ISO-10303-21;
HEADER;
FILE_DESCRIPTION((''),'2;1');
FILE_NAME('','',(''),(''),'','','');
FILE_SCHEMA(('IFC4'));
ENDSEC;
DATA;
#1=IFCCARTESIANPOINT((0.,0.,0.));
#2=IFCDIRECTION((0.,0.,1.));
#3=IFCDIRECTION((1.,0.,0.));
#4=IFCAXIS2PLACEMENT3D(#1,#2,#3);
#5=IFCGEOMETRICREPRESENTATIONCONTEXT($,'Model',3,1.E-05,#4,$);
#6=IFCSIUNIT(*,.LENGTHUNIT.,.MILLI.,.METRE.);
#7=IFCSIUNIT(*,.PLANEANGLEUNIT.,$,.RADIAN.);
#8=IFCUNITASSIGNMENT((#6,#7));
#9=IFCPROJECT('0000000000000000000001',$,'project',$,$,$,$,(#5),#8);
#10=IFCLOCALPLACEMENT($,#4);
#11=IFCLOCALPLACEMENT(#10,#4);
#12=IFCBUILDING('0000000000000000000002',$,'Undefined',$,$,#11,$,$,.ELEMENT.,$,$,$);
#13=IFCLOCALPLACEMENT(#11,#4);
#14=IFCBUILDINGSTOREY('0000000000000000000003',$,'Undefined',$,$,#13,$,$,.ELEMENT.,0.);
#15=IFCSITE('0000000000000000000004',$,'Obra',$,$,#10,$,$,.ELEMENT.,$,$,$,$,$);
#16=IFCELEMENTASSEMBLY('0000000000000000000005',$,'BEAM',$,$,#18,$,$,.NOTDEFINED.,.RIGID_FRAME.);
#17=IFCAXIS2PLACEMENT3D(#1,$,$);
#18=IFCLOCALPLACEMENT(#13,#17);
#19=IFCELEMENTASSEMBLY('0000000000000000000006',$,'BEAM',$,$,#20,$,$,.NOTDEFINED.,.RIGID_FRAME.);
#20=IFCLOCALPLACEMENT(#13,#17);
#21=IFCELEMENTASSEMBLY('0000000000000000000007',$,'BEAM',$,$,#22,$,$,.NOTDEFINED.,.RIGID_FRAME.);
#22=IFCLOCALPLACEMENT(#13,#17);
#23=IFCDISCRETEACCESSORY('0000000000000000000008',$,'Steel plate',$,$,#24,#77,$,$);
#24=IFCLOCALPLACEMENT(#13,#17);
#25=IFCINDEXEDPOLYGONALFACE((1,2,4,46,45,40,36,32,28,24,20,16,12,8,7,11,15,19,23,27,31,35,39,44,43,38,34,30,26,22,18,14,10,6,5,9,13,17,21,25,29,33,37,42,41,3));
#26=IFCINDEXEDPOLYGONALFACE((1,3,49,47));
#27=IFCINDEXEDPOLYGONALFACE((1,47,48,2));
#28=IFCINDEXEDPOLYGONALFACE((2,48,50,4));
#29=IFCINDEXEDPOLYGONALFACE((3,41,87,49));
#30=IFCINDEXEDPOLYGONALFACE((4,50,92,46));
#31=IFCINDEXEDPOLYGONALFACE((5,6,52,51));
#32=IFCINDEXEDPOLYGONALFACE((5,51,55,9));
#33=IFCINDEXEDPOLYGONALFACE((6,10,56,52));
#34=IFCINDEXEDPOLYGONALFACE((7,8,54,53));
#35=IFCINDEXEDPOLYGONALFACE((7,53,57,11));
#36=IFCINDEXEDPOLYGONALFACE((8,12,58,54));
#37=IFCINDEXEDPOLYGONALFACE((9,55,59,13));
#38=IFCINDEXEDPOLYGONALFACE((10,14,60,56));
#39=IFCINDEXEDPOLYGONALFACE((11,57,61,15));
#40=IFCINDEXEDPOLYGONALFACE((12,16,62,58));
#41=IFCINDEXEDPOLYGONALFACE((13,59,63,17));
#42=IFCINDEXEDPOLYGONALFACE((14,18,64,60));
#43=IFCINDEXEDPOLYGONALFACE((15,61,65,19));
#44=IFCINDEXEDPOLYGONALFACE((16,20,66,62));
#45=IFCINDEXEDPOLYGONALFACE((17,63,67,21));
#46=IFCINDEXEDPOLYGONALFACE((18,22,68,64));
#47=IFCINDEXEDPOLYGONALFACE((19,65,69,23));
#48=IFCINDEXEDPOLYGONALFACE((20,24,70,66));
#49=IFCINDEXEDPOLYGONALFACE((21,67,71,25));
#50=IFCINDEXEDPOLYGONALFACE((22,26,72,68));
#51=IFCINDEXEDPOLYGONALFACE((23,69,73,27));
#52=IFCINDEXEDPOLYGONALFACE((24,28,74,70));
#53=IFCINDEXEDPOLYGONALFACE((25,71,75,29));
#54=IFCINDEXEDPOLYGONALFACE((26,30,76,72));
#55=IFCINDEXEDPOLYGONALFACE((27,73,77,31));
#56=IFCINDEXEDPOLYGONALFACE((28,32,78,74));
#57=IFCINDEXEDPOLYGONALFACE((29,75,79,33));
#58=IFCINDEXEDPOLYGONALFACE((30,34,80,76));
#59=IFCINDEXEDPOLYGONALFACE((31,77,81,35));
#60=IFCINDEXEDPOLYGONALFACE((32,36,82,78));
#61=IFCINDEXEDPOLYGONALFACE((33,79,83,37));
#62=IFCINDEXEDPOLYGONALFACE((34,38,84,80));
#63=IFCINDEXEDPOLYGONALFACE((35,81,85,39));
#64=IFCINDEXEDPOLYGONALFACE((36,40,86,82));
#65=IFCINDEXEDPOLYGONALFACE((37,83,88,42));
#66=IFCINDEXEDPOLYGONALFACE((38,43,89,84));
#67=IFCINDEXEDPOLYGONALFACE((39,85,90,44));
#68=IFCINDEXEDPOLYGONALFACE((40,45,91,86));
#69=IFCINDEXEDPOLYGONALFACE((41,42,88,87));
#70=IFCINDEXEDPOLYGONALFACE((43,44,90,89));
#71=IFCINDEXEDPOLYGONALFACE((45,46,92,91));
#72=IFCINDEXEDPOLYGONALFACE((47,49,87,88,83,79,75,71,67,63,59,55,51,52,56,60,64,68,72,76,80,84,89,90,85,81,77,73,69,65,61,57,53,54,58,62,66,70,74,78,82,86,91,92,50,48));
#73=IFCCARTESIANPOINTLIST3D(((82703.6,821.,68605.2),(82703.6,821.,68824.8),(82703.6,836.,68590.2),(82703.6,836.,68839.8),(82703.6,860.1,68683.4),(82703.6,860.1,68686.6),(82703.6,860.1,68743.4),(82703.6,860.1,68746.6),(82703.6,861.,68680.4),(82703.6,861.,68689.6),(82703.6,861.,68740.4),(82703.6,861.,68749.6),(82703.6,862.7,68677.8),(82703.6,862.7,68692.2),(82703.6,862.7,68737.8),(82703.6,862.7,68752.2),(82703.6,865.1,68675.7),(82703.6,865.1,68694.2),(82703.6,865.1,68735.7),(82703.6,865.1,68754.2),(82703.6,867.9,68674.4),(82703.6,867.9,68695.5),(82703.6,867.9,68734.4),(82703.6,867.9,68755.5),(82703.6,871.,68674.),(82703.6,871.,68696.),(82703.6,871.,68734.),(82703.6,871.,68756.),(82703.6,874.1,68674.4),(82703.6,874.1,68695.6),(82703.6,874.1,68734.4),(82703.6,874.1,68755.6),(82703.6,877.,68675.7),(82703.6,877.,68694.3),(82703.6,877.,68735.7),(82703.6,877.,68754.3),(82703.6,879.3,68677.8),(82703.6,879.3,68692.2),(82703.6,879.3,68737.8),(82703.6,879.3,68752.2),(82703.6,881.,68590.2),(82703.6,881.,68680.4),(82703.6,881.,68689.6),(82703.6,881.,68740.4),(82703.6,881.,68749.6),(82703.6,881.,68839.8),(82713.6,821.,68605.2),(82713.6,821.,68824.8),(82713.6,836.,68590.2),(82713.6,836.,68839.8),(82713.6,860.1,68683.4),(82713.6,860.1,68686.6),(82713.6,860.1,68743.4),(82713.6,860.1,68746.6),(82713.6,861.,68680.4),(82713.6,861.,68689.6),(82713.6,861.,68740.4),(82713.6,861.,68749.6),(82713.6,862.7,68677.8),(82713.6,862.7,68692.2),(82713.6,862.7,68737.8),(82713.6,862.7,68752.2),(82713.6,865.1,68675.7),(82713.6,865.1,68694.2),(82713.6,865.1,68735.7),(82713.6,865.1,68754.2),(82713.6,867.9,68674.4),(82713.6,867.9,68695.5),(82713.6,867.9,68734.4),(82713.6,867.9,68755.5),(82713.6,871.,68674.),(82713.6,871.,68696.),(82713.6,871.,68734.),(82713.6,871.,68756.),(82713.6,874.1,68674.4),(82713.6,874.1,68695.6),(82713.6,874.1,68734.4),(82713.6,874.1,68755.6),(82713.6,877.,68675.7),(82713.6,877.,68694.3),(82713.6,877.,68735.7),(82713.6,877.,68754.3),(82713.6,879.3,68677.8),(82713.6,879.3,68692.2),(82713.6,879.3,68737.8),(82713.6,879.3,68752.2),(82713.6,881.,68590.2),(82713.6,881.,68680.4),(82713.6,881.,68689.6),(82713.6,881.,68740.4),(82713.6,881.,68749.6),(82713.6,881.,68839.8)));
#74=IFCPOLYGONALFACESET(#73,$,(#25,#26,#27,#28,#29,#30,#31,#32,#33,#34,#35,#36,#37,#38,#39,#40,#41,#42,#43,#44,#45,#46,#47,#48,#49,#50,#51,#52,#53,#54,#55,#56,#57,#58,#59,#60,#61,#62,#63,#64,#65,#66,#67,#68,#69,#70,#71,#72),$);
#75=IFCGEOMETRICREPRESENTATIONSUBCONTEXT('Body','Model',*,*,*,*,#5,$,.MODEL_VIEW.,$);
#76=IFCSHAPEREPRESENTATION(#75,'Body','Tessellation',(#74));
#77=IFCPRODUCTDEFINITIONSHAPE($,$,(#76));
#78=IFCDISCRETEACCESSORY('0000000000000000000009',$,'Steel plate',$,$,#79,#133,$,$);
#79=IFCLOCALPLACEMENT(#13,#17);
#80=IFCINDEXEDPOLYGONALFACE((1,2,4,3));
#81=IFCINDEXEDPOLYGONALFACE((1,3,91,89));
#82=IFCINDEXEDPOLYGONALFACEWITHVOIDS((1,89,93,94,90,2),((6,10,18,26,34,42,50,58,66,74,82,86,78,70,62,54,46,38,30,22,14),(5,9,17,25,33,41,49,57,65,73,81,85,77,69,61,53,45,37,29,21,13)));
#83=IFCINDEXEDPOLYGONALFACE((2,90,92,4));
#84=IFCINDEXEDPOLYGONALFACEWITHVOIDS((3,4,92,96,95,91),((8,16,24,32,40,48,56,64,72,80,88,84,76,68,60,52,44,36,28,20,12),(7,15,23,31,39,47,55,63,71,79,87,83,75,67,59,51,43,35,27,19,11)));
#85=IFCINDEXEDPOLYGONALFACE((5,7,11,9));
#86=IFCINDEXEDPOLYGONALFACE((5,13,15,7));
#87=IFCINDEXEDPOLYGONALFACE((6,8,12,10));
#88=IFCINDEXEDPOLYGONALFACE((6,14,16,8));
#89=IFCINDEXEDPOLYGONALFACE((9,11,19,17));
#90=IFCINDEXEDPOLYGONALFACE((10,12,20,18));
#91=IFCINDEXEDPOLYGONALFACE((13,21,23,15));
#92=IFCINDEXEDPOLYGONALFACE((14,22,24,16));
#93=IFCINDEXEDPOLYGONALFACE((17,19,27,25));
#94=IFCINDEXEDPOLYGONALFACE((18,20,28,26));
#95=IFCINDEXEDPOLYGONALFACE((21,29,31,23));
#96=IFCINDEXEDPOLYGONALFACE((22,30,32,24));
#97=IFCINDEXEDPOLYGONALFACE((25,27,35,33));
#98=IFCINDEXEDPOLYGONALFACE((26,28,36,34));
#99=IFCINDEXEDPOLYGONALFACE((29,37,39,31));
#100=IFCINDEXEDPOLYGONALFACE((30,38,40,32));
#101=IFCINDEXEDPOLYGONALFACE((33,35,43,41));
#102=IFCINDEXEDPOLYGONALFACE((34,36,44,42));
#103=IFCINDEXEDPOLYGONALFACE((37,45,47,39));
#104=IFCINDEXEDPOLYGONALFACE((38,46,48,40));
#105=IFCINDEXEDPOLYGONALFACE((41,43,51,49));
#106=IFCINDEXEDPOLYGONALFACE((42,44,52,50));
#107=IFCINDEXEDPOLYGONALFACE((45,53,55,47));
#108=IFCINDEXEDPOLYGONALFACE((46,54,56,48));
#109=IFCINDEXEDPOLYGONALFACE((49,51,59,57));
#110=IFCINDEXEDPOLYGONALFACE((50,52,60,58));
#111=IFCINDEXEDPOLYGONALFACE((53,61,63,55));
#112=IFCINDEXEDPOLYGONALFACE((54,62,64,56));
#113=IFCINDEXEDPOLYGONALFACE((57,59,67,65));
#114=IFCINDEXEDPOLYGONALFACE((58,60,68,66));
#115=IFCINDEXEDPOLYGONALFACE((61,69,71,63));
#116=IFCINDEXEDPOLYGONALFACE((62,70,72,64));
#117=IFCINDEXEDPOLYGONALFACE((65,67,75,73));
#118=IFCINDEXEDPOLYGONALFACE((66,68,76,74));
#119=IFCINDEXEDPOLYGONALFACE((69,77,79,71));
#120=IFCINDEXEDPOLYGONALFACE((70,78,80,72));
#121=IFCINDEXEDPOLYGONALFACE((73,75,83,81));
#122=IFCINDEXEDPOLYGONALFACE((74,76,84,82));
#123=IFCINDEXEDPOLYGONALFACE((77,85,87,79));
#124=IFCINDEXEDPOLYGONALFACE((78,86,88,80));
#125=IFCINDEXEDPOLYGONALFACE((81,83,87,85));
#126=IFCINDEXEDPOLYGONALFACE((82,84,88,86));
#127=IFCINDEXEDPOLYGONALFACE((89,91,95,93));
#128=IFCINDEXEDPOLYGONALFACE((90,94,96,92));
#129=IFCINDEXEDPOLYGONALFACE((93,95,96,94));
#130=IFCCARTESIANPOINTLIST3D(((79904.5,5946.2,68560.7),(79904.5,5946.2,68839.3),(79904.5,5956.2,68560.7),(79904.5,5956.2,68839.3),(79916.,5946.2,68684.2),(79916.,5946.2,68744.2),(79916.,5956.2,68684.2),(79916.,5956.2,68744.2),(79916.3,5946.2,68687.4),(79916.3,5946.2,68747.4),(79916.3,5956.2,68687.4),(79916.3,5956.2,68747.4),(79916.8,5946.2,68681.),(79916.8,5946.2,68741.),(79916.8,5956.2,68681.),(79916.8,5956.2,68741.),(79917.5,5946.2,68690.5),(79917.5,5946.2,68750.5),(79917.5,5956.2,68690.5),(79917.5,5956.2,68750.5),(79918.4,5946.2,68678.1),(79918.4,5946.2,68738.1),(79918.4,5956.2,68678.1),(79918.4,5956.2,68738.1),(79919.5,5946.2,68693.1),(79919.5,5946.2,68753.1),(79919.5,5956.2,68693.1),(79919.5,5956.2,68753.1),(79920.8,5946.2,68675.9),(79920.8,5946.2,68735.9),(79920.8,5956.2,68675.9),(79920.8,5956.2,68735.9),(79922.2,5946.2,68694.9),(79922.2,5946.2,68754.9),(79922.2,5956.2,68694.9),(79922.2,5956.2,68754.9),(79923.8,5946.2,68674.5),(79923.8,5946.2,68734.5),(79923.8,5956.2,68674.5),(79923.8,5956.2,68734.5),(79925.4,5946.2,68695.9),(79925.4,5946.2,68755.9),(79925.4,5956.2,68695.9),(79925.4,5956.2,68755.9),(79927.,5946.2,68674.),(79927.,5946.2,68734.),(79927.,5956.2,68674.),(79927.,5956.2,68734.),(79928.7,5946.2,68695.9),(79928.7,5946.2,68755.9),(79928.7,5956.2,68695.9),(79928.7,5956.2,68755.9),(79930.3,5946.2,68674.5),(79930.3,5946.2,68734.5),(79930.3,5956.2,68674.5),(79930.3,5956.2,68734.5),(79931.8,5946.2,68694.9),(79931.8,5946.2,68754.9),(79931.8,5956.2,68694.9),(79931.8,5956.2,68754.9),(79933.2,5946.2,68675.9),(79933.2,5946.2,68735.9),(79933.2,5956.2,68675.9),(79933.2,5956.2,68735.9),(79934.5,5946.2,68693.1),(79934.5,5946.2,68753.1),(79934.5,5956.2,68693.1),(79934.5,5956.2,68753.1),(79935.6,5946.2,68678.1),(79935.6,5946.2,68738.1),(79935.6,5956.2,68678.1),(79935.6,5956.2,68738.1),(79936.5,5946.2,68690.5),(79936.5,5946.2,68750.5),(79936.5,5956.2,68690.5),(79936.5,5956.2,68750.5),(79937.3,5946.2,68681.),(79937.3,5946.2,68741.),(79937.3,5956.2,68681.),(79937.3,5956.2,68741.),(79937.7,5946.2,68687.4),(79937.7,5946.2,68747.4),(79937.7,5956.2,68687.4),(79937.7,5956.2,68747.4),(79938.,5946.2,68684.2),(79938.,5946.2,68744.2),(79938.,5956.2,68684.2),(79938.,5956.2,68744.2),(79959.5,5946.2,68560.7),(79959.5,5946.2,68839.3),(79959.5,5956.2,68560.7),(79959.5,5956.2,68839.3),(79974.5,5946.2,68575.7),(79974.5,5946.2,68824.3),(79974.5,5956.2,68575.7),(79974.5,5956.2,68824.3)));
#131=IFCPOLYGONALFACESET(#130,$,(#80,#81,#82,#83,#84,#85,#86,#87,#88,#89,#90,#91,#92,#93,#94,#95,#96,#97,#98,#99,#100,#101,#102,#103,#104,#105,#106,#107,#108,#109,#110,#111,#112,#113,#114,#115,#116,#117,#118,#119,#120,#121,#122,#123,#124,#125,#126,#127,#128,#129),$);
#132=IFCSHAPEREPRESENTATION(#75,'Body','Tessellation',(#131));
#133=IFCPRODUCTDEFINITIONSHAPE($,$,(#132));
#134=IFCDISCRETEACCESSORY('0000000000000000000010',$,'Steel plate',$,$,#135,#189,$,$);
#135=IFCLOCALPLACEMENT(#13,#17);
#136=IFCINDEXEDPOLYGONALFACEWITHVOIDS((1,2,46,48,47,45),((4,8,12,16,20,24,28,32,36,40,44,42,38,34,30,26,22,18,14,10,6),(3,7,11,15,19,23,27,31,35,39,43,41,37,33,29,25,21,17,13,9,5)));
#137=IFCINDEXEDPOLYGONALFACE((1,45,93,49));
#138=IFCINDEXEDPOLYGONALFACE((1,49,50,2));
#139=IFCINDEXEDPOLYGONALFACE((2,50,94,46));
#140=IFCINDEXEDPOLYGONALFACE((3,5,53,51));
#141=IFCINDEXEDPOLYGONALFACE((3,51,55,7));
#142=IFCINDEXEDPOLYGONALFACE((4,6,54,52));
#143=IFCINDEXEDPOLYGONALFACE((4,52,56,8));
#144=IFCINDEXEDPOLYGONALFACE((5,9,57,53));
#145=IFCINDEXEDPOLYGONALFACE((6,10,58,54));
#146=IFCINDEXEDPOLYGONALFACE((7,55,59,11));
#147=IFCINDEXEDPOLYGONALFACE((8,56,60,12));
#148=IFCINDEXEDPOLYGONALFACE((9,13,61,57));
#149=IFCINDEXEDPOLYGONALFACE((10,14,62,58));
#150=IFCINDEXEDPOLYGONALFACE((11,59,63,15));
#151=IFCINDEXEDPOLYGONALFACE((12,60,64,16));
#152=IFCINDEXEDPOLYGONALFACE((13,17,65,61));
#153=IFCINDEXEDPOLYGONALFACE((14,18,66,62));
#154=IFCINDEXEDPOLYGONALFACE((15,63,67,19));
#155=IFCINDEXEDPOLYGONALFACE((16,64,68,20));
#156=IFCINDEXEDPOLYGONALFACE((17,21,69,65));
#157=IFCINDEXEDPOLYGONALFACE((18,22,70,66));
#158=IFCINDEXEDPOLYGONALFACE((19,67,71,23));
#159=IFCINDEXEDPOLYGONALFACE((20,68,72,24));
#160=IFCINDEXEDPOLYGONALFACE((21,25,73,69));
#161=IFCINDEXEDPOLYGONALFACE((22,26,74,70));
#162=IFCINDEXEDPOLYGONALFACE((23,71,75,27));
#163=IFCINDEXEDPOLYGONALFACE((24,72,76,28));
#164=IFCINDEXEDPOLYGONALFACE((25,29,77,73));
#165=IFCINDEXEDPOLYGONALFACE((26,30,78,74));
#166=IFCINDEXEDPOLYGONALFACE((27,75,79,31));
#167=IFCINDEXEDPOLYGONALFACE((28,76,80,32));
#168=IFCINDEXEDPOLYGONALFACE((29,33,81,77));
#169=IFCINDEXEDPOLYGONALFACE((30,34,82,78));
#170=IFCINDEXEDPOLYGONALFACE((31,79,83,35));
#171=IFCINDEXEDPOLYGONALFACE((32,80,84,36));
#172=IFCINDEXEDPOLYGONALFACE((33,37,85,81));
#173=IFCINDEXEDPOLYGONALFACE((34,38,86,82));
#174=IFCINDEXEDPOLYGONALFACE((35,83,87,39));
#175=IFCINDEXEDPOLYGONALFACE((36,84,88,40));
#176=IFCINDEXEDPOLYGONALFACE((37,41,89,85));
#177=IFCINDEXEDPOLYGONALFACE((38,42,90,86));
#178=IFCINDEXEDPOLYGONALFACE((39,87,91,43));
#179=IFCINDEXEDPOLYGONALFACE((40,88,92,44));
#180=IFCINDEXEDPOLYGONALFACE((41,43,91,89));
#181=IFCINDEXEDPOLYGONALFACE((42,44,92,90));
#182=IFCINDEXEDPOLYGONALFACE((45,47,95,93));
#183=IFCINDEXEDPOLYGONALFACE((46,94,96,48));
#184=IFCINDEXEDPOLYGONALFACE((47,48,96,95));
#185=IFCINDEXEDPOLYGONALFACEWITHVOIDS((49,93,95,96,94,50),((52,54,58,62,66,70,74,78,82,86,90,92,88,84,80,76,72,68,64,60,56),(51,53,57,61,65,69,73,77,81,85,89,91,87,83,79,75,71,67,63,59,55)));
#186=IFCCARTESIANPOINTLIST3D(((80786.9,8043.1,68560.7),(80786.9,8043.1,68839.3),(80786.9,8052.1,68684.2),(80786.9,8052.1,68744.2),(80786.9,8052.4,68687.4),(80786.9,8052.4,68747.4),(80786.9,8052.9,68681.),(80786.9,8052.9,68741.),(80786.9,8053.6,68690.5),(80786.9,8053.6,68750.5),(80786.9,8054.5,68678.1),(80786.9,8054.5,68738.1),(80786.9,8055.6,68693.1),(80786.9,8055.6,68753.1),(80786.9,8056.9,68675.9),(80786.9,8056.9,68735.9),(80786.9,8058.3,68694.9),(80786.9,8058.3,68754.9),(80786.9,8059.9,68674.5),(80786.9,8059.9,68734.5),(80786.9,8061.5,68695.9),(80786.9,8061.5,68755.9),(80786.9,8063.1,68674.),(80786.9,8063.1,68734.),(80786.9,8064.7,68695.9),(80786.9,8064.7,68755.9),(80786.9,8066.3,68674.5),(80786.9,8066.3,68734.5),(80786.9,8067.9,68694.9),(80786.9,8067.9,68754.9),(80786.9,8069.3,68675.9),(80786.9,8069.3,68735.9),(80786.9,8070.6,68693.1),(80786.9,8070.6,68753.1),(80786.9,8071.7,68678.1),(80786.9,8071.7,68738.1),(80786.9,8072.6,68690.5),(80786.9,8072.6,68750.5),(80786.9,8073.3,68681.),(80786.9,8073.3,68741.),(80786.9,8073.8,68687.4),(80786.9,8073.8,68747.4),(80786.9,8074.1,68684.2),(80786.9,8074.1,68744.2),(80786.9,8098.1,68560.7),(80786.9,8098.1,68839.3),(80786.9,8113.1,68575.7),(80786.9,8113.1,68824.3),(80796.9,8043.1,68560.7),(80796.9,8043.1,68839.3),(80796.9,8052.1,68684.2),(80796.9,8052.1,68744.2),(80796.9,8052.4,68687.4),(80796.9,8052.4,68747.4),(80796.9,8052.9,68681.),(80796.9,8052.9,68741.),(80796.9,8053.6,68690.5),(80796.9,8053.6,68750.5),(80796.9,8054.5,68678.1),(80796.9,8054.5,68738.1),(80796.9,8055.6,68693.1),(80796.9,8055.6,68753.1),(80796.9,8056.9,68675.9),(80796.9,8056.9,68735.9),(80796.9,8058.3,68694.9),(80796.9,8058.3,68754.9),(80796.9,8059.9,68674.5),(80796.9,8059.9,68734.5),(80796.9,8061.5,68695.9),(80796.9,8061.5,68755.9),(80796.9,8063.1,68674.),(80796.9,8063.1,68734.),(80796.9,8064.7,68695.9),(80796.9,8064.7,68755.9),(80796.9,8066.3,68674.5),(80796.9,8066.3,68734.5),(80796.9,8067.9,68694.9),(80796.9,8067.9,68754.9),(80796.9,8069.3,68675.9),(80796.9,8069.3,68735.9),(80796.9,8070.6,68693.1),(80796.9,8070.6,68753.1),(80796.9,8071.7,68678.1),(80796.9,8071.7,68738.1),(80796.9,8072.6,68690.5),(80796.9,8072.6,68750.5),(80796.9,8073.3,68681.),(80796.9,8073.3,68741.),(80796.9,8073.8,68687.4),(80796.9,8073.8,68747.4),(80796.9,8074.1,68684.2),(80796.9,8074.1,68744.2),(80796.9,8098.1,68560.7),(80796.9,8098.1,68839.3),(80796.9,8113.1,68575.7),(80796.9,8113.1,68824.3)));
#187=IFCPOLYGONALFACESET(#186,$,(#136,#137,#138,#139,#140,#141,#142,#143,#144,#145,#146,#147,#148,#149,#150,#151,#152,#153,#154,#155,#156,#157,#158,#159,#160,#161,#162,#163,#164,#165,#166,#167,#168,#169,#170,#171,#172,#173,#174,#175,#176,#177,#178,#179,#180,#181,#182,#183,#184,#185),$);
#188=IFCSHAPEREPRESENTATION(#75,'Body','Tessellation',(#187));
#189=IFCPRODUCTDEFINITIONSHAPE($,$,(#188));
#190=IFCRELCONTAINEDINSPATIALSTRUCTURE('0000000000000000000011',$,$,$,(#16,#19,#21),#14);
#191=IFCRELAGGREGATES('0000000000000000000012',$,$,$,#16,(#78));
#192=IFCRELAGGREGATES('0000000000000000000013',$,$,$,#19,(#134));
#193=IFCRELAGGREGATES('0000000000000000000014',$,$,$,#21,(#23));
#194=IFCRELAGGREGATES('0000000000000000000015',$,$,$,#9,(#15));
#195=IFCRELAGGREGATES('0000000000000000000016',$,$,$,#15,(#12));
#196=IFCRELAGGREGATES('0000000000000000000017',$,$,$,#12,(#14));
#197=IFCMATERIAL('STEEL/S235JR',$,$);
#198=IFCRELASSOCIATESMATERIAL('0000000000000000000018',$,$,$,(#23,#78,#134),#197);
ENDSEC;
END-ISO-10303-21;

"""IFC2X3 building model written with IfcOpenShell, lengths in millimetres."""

from ifc_helpers import new_model, si_unit, frame, origin_with_axes, origin_2d_with_axis, place, context, subcontext, project, spatial, polyline, circle, outline, extrude, source, transform, mapped, material, element, aggregate, save


model = new_model("IFC2X3")

# Units and contexts
model_context = context("Model", 3, precision=1e-05, world=origin_with_axes())
body_context = subcontext(model_context, "Body", "Model", "MODEL_VIEW")
ifc_project = project(units=[si_unit("LENGTHUNIT", "METRE", prefix="MILLI"), si_unit("PLANEANGLEUNIT", "RADIAN")], contexts=[model_context])

# Site, building, storey
site_placement = place(None, origin_with_axes())
site = spatial("IfcSite", under=ifc_project, at=site_placement, Name="Obra", CompositionType="ELEMENT")
building_placement = place(site_placement, origin_with_axes())
building = spatial("IfcBuilding", under=site, at=building_placement, Name="Undefined", CompositionType="ELEMENT")
storey_placement = place(building_placement, origin_with_axes())
storey = spatial("IfcBuildingStorey", under=building, at=storey_placement, Name="Undefined", CompositionType="ELEMENT", Elevation=0.0)

# Shared definitions
ifc_material = material(Name="STEEL/S235JR")

# Element assembly
assembly_1_placement = place(storey_placement, origin_with_axes())
assembly_1 = element("IfcElementAssembly", 1, at=assembly_1_placement, inside=storey, Name="BEAM", AssemblyPlace="NOTDEFINED", PredefinedType="RIGID_FRAME")

# Element assembly
assembly_2_placement = place(storey_placement, origin_with_axes())
assembly_2 = element("IfcElementAssembly", 2, at=assembly_2_placement, inside=storey, Name="BEAM", AssemblyPlace="NOTDEFINED", PredefinedType="RIGID_FRAME")
shared_shape_1 = source(origin_with_axes(), body_context, "Body", "SweptSolid", [
    extrude(circle(Radius=11.0, at=origin_2d_with_axis()), frame((0.0, -13.4, 0.0), z_axis=(0.0, 1.0, 0.0), x_axis=(1.0, 0.0, 0.0)), (0.0, 0.0, 1.0), 10.2),
])

# Element assembly, discrete accessory, opening
assembly_3_placement = place(storey_placement, origin_with_axes())
assembly_3 = element("IfcElementAssembly", 3, at=assembly_3_placement, inside=storey, Name="BEAM", AssemblyPlace="NOTDEFINED", PredefinedType="RIGID_FRAME")
discrete_accessory_1_placement = place(assembly_3_placement, frame((82708.6, 881.0, 68590.2), z_axis=(-1.0, 0.0, 0.0), x_axis=(0.0, -1.0, 0.0)))
discrete_accessory_1 = element("IfcDiscreteAccessory", 4, at=discrete_accessory_1_placement, material=ifc_material, Name="Steel plate", context=body_context, shape_type="SweptSolid", body=[
    extrude(outline(polyline([(0.0, 0.0), (45.0, 0.0), (60.0, 15.0), (60.0, 234.6), (45.0, 249.6), (0.0, 249.6), (0.0, 0.0)])), frame((0.0, 0.0, -5.0), z_axis=(0.0, 0.0, 1.0), x_axis=(1.0, 0.0, 0.0)), (0.0, 0.0, 1.0), 10.0),
])
opening_1_placement = place(assembly_3_placement, frame((82700.3, 831.0, 68850.0), z_axis=(0.0, 1.0, 0.0), x_axis=(0.0, 0.0, -1.0)))
element("IfcOpeningElement", 5, at=opening_1_placement, cuts=discrete_accessory_1, ObjectType="Opening", context=body_context, shape_type="MappedRepresentation", body=[
    mapped(shared_shape_1, transform((105.0, 0.0, 40.0))),
    mapped(shared_shape_1, transform((165.0, 0.0, 40.0))),
])

# Discrete accessories, openings
discrete_accessory_2_placement = place(assembly_1_placement, frame((79904.5, 5951.2, 68560.7), z_axis=(0.0, -1.0, 0.0), x_axis=(1.0, 0.0, 0.0)))
discrete_accessory_2 = element("IfcDiscreteAccessory", 6, at=discrete_accessory_2_placement, material=ifc_material, Name="Steel plate", context=body_context, shape_type="SweptSolid", body=[
    extrude(outline(polyline([(0.0, 0.0), (55.0, 0.0), (70.0, 15.0), (70.0, 263.6), (55.0, 278.6), (0.0, 278.6), (0.0, 0.0)])), frame((0.0, 0.0, -5.0), z_axis=(0.0, 0.0, 1.0), x_axis=(1.0, 0.0, 0.0)), (0.0, 0.0, 1.0), 10.0),
])
shared_shape_2 = source(origin_with_axes(), body_context, "Body", "SweptSolid", [
    extrude(circle(Radius=11.0, at=origin_2d_with_axis()), frame((0.0, -13.7, 0.0), z_axis=(0.0, 1.0, 0.0), x_axis=(1.0, 0.0, 0.0)), (0.0, 0.0, 1.0), 10.2),
])
opening_2_placement = place(assembly_1_placement, frame((79967.0, 5942.5, 68850.0), z_axis=(-1.0, 0.0, 0.0), x_axis=(0.0, 0.0, -1.0)))
element("IfcOpeningElement", 7, at=opening_2_placement, cuts=discrete_accessory_2, ObjectType="Opening", context=body_context, shape_type="MappedRepresentation", body=[
    mapped(shared_shape_2, transform((105.0, 0.0, 40.0))),
    mapped(shared_shape_2, transform((165.0, 0.0, 40.0))),
])
aggregate(assembly_1, [discrete_accessory_2])
discrete_accessory_3_placement = place(assembly_2_placement, frame((80791.9, 8043.1, 68560.7), z_axis=(1.0, 0.0, 0.0), x_axis=(0.0, 1.0, 0.0)))
discrete_accessory_3 = element("IfcDiscreteAccessory", 8, at=discrete_accessory_3_placement, material=ifc_material, Name="Steel plate", context=body_context, shape_type="SweptSolid", body=[
    extrude(outline(polyline([(0.0, 0.0), (55.0, 0.0), (70.0, 15.0), (70.0, 263.6), (55.0, 278.6), (0.0, 278.6), (0.0, 0.0)])), frame((0.0, 0.0, -5.0), z_axis=(0.0, 0.0, 1.0), x_axis=(1.0, 0.0, 0.0)), (0.0, 0.0, 1.0), 10.0),
])
opening_3_placement = place(assembly_2_placement, frame((80800.2, 8103.1, 68850.0), z_axis=(0.0, -1.0, 0.0), x_axis=(0.0, 0.0, -1.0)))
element("IfcOpeningElement", 9, at=opening_3_placement, cuts=discrete_accessory_3, ObjectType="Opening", context=body_context, shape_type="MappedRepresentation", body=[
    mapped(shared_shape_1, transform((105.0, 0.0, 40.0))),
    mapped(shared_shape_1, transform((165.0, 0.0, 40.0))),
])
aggregate(assembly_2, [discrete_accessory_3])
aggregate(assembly_3, [discrete_accessory_1])

save(model, "model.ifc")
